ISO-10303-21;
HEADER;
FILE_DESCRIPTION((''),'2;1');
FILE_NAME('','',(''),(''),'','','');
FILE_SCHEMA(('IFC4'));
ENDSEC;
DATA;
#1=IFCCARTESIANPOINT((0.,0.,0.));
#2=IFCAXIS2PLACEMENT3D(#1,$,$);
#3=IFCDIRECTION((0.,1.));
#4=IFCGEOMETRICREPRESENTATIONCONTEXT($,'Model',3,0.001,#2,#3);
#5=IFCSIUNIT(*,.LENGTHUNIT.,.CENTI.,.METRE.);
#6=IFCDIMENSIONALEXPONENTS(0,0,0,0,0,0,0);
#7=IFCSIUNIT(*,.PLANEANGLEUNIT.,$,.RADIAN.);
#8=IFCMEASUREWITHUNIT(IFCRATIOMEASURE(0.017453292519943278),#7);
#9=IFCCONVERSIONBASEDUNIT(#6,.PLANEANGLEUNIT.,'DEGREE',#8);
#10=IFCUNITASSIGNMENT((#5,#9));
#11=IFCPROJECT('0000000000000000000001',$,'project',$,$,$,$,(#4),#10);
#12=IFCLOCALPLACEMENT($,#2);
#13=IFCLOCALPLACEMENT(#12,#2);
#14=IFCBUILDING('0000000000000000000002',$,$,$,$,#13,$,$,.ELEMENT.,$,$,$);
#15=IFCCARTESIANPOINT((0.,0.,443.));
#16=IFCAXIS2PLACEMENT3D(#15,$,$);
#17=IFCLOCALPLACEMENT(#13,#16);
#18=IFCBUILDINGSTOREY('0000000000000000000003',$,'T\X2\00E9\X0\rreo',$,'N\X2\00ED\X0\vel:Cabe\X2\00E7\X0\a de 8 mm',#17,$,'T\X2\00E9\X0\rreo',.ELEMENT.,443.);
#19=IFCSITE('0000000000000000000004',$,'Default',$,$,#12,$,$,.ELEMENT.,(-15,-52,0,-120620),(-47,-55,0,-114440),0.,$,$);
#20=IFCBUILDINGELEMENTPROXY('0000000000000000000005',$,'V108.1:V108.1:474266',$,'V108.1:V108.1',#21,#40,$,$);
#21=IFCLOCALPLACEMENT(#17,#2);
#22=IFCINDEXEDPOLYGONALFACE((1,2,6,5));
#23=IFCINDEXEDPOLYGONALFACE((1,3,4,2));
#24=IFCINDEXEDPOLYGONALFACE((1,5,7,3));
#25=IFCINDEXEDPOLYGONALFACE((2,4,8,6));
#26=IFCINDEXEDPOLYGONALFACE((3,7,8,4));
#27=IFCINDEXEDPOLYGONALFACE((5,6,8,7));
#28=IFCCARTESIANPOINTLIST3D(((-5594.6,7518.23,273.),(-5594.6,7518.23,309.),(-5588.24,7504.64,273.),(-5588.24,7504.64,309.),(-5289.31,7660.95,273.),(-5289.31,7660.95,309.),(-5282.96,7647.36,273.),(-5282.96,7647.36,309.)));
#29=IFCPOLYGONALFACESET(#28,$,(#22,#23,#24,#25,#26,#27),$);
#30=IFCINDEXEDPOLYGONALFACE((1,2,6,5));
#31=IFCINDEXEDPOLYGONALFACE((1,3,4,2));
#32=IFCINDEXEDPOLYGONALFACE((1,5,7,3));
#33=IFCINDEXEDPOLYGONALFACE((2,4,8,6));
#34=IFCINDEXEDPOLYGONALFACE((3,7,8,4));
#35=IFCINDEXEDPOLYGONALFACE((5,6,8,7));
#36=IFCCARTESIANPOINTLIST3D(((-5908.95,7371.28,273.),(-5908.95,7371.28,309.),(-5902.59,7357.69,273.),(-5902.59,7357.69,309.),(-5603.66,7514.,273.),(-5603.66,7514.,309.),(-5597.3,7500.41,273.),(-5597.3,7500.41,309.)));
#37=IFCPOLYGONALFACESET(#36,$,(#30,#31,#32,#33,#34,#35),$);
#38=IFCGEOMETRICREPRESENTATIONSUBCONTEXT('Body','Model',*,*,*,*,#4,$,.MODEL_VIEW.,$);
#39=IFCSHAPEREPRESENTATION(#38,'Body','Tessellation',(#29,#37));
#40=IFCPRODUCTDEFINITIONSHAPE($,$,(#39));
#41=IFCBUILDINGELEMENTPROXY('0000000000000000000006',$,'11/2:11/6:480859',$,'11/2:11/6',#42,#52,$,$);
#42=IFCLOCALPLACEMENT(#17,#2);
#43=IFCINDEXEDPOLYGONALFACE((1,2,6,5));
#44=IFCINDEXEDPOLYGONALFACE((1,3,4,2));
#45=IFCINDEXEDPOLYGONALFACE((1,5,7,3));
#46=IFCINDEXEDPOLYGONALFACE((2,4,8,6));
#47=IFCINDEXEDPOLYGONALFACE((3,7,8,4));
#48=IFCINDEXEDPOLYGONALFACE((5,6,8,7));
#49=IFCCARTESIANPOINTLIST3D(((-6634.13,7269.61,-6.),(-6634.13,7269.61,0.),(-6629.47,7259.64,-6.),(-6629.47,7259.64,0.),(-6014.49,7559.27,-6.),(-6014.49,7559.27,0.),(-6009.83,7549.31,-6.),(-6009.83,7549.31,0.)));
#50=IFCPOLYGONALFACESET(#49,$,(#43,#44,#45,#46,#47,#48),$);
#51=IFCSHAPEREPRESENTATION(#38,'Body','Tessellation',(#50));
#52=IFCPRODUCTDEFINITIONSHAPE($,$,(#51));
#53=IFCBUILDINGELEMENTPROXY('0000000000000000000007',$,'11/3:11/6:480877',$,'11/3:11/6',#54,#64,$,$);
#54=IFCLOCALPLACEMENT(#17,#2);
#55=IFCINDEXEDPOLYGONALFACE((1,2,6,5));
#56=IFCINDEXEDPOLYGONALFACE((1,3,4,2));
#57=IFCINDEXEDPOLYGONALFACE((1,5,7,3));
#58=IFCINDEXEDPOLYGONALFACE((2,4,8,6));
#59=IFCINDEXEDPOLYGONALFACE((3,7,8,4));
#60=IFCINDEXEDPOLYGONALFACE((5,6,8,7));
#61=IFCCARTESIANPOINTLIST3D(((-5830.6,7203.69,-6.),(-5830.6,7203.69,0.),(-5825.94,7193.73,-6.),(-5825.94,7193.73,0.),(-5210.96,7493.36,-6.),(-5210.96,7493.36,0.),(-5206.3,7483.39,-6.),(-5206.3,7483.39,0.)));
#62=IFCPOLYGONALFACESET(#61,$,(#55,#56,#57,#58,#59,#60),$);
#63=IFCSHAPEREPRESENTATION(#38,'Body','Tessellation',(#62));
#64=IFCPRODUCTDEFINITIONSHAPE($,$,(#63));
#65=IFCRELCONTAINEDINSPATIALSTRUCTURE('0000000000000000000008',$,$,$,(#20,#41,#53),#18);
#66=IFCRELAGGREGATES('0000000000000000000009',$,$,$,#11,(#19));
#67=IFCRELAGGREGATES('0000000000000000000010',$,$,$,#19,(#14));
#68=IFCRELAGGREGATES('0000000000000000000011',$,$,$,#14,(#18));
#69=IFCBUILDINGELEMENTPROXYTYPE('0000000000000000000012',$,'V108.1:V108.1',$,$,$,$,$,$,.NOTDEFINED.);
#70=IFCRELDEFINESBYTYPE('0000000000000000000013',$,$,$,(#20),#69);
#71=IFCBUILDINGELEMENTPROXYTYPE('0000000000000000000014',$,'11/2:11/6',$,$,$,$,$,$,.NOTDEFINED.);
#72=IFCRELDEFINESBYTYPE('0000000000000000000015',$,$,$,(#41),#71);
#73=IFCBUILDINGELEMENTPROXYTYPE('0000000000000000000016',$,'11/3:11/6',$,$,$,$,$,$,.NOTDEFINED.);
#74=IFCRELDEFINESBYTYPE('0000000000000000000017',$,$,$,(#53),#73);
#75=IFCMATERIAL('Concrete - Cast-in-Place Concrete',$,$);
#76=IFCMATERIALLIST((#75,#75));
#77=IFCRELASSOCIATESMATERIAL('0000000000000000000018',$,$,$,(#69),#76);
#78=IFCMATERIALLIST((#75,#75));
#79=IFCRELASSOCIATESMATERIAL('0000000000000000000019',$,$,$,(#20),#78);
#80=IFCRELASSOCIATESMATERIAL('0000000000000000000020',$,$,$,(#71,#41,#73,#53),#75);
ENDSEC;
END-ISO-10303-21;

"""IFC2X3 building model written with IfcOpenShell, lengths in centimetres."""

from ifc_helpers import new_model, entity, si_unit, converted_unit, direction, frame, frame_2d, origin, origin_2d_with_axis, place, context, subcontext, project, spatial, rectangle, extrude, source, transform, mapped, material, material_list, type_object, type_shapes, element, save


model = new_model("IFC2X3")

# Units and contexts
model_context = context("Model", 3, precision=0.001, world=origin(), true_north=direction((0.0, 1.0)))
body_context = subcontext(model_context, "Body", "Model", "MODEL_VIEW")
ifc_project = project(units=[si_unit("LENGTHUNIT", "METRE", prefix="CENTI"), converted_unit("PLANEANGLEUNIT", "DEGREE", entity("IfcRatioMeasure", 0.017453292519943278), si_unit("PLANEANGLEUNIT", "RADIAN"), dimensions=[0, 0, 0, 0, 0, 0, 0])], contexts=[model_context])

# Site, building, storey
site_placement = place(None, origin())
site = spatial("IfcSite", under=ifc_project, at=site_placement, Name="Default", CompositionType="ELEMENT", RefLatitude=(-15, -52, 0, -120620), RefLongitude=(-47, -55, 0, -114440), RefElevation=0.0)
building_placement = place(site_placement, origin())
building = spatial("IfcBuilding", under=site, at=building_placement, CompositionType="ELEMENT")
storey_placement = place(building_placement, frame((0.0, 0.0, 443.0)))
storey = spatial("IfcBuildingStorey", under=building, at=storey_placement, Name="Térreo", ObjectType="Nível:Cabeça de 8 mm", LongName="Térreo", CompositionType="ELEMENT", Elevation=443.0)

# Building element proxies
ifc_material_1 = material(Name="Concrete - Cast-in-Place Concrete")
ifc_material_list_1 = material_list([ifc_material_1, ifc_material_1])
ifc_material_list_2 = material_list([ifc_material_1, ifc_material_1])
building_element_proxy_type_1 = type_object("IfcBuildingElementProxyType", Name="V108.1:V108.1", PredefinedType="NOTDEFINED", material=ifc_material_list_2)
shared_shape_1 = source(origin(), body_context, "Body", "SweptSolid", [
    extrude(rectangle(XDim=337.0, YDim=15.0, at=frame_2d((0.0, 0.0), x_axis=(1.0, 0.0))), frame((470.17, 225.1, 0.0), z_axis=(0.0, 0.0, 1.0), x_axis=(-0.905902, -0.423488, 0.0)), (0.0, 0.0, 1.0), 36.0),
    extrude(rectangle(XDim=337.0, YDim=15.0, at=frame_2d((0.0, 0.0), x_axis=(1.0, 0.0))), frame((155.82, 78.15, 0.0), z_axis=(0.0, 0.0, 1.0), x_axis=(-0.905902, -0.423488, 0.0)), (0.0, 0.0, 1.0), 36.0),
])
type_shapes(building_element_proxy_type_1, [shared_shape_1])
proxy_1_placement = place(storey_placement, frame((-5908.95, 7357.69, 273.0)))
element("IfcBuildingElementProxy", 1, at=proxy_1_placement, inside=storey, type_object=building_element_proxy_type_1, material=ifc_material_list_1, Name="V108.1:V108.1:474266", ObjectType="V108.1:V108.1", context=body_context, shape_type="MappedRepresentation", body=[
    mapped(shared_shape_1, transform((0.0, 0.0, 0.0), scale=1.0)),
])
building_element_proxy_type_2 = type_object("IfcBuildingElementProxyType", Name="11/2:11/6", PredefinedType="NOTDEFINED", material=ifc_material_1)
shared_shape_2 = source(origin(), body_context, "Body", "SweptSolid", [
    extrude(rectangle(XDim=11.0, YDim=684.0, at=origin_2d_with_axis()), frame((312.15, 149.82, 0.0), z_axis=(0.0, 0.0, 1.0), x_axis=(0.423488, -0.905902, 0.0)), (0.0, 0.0, 1.0), 6.0),
])
type_shapes(building_element_proxy_type_2, [shared_shape_2])
proxy_2_placement = place(storey_placement, frame((-6634.13, 7259.64, -6.0)))
element("IfcBuildingElementProxy", 2, at=proxy_2_placement, inside=storey, type_object=building_element_proxy_type_2, material=ifc_material_1, Name="11/2:11/6:480859", ObjectType="11/2:11/6", context=body_context, shape_type="MappedRepresentation", body=[
    mapped(shared_shape_2, transform((0.0, 0.0, 0.0), scale=1.0)),
])
building_element_proxy_type_3 = type_object("IfcBuildingElementProxyType", Name="11/3:11/6", PredefinedType="NOTDEFINED", material=ifc_material_1)
shared_shape_3 = source(origin(), body_context, "Body", "SweptSolid", [
    extrude(rectangle(XDim=11.0, YDim=684.0, at=origin_2d_with_axis()), frame((312.15, 149.82, 0.0), z_axis=(0.0, 0.0, 1.0), x_axis=(0.423488, -0.905902, 0.0)), (0.0, 0.0, 1.0), 6.0),
])
type_shapes(building_element_proxy_type_3, [shared_shape_3])
proxy_3_placement = place(storey_placement, frame((-5830.6, 7193.73, -6.0)))
element("IfcBuildingElementProxy", 3, at=proxy_3_placement, inside=storey, type_object=building_element_proxy_type_3, material=ifc_material_1, Name="11/3:11/6:480877", ObjectType="11/3:11/6", context=body_context, shape_type="MappedRepresentation", body=[
    mapped(shared_shape_3, transform((0.0, 0.0, 0.0), scale=1.0)),
])

save(model, "model.ifc")
